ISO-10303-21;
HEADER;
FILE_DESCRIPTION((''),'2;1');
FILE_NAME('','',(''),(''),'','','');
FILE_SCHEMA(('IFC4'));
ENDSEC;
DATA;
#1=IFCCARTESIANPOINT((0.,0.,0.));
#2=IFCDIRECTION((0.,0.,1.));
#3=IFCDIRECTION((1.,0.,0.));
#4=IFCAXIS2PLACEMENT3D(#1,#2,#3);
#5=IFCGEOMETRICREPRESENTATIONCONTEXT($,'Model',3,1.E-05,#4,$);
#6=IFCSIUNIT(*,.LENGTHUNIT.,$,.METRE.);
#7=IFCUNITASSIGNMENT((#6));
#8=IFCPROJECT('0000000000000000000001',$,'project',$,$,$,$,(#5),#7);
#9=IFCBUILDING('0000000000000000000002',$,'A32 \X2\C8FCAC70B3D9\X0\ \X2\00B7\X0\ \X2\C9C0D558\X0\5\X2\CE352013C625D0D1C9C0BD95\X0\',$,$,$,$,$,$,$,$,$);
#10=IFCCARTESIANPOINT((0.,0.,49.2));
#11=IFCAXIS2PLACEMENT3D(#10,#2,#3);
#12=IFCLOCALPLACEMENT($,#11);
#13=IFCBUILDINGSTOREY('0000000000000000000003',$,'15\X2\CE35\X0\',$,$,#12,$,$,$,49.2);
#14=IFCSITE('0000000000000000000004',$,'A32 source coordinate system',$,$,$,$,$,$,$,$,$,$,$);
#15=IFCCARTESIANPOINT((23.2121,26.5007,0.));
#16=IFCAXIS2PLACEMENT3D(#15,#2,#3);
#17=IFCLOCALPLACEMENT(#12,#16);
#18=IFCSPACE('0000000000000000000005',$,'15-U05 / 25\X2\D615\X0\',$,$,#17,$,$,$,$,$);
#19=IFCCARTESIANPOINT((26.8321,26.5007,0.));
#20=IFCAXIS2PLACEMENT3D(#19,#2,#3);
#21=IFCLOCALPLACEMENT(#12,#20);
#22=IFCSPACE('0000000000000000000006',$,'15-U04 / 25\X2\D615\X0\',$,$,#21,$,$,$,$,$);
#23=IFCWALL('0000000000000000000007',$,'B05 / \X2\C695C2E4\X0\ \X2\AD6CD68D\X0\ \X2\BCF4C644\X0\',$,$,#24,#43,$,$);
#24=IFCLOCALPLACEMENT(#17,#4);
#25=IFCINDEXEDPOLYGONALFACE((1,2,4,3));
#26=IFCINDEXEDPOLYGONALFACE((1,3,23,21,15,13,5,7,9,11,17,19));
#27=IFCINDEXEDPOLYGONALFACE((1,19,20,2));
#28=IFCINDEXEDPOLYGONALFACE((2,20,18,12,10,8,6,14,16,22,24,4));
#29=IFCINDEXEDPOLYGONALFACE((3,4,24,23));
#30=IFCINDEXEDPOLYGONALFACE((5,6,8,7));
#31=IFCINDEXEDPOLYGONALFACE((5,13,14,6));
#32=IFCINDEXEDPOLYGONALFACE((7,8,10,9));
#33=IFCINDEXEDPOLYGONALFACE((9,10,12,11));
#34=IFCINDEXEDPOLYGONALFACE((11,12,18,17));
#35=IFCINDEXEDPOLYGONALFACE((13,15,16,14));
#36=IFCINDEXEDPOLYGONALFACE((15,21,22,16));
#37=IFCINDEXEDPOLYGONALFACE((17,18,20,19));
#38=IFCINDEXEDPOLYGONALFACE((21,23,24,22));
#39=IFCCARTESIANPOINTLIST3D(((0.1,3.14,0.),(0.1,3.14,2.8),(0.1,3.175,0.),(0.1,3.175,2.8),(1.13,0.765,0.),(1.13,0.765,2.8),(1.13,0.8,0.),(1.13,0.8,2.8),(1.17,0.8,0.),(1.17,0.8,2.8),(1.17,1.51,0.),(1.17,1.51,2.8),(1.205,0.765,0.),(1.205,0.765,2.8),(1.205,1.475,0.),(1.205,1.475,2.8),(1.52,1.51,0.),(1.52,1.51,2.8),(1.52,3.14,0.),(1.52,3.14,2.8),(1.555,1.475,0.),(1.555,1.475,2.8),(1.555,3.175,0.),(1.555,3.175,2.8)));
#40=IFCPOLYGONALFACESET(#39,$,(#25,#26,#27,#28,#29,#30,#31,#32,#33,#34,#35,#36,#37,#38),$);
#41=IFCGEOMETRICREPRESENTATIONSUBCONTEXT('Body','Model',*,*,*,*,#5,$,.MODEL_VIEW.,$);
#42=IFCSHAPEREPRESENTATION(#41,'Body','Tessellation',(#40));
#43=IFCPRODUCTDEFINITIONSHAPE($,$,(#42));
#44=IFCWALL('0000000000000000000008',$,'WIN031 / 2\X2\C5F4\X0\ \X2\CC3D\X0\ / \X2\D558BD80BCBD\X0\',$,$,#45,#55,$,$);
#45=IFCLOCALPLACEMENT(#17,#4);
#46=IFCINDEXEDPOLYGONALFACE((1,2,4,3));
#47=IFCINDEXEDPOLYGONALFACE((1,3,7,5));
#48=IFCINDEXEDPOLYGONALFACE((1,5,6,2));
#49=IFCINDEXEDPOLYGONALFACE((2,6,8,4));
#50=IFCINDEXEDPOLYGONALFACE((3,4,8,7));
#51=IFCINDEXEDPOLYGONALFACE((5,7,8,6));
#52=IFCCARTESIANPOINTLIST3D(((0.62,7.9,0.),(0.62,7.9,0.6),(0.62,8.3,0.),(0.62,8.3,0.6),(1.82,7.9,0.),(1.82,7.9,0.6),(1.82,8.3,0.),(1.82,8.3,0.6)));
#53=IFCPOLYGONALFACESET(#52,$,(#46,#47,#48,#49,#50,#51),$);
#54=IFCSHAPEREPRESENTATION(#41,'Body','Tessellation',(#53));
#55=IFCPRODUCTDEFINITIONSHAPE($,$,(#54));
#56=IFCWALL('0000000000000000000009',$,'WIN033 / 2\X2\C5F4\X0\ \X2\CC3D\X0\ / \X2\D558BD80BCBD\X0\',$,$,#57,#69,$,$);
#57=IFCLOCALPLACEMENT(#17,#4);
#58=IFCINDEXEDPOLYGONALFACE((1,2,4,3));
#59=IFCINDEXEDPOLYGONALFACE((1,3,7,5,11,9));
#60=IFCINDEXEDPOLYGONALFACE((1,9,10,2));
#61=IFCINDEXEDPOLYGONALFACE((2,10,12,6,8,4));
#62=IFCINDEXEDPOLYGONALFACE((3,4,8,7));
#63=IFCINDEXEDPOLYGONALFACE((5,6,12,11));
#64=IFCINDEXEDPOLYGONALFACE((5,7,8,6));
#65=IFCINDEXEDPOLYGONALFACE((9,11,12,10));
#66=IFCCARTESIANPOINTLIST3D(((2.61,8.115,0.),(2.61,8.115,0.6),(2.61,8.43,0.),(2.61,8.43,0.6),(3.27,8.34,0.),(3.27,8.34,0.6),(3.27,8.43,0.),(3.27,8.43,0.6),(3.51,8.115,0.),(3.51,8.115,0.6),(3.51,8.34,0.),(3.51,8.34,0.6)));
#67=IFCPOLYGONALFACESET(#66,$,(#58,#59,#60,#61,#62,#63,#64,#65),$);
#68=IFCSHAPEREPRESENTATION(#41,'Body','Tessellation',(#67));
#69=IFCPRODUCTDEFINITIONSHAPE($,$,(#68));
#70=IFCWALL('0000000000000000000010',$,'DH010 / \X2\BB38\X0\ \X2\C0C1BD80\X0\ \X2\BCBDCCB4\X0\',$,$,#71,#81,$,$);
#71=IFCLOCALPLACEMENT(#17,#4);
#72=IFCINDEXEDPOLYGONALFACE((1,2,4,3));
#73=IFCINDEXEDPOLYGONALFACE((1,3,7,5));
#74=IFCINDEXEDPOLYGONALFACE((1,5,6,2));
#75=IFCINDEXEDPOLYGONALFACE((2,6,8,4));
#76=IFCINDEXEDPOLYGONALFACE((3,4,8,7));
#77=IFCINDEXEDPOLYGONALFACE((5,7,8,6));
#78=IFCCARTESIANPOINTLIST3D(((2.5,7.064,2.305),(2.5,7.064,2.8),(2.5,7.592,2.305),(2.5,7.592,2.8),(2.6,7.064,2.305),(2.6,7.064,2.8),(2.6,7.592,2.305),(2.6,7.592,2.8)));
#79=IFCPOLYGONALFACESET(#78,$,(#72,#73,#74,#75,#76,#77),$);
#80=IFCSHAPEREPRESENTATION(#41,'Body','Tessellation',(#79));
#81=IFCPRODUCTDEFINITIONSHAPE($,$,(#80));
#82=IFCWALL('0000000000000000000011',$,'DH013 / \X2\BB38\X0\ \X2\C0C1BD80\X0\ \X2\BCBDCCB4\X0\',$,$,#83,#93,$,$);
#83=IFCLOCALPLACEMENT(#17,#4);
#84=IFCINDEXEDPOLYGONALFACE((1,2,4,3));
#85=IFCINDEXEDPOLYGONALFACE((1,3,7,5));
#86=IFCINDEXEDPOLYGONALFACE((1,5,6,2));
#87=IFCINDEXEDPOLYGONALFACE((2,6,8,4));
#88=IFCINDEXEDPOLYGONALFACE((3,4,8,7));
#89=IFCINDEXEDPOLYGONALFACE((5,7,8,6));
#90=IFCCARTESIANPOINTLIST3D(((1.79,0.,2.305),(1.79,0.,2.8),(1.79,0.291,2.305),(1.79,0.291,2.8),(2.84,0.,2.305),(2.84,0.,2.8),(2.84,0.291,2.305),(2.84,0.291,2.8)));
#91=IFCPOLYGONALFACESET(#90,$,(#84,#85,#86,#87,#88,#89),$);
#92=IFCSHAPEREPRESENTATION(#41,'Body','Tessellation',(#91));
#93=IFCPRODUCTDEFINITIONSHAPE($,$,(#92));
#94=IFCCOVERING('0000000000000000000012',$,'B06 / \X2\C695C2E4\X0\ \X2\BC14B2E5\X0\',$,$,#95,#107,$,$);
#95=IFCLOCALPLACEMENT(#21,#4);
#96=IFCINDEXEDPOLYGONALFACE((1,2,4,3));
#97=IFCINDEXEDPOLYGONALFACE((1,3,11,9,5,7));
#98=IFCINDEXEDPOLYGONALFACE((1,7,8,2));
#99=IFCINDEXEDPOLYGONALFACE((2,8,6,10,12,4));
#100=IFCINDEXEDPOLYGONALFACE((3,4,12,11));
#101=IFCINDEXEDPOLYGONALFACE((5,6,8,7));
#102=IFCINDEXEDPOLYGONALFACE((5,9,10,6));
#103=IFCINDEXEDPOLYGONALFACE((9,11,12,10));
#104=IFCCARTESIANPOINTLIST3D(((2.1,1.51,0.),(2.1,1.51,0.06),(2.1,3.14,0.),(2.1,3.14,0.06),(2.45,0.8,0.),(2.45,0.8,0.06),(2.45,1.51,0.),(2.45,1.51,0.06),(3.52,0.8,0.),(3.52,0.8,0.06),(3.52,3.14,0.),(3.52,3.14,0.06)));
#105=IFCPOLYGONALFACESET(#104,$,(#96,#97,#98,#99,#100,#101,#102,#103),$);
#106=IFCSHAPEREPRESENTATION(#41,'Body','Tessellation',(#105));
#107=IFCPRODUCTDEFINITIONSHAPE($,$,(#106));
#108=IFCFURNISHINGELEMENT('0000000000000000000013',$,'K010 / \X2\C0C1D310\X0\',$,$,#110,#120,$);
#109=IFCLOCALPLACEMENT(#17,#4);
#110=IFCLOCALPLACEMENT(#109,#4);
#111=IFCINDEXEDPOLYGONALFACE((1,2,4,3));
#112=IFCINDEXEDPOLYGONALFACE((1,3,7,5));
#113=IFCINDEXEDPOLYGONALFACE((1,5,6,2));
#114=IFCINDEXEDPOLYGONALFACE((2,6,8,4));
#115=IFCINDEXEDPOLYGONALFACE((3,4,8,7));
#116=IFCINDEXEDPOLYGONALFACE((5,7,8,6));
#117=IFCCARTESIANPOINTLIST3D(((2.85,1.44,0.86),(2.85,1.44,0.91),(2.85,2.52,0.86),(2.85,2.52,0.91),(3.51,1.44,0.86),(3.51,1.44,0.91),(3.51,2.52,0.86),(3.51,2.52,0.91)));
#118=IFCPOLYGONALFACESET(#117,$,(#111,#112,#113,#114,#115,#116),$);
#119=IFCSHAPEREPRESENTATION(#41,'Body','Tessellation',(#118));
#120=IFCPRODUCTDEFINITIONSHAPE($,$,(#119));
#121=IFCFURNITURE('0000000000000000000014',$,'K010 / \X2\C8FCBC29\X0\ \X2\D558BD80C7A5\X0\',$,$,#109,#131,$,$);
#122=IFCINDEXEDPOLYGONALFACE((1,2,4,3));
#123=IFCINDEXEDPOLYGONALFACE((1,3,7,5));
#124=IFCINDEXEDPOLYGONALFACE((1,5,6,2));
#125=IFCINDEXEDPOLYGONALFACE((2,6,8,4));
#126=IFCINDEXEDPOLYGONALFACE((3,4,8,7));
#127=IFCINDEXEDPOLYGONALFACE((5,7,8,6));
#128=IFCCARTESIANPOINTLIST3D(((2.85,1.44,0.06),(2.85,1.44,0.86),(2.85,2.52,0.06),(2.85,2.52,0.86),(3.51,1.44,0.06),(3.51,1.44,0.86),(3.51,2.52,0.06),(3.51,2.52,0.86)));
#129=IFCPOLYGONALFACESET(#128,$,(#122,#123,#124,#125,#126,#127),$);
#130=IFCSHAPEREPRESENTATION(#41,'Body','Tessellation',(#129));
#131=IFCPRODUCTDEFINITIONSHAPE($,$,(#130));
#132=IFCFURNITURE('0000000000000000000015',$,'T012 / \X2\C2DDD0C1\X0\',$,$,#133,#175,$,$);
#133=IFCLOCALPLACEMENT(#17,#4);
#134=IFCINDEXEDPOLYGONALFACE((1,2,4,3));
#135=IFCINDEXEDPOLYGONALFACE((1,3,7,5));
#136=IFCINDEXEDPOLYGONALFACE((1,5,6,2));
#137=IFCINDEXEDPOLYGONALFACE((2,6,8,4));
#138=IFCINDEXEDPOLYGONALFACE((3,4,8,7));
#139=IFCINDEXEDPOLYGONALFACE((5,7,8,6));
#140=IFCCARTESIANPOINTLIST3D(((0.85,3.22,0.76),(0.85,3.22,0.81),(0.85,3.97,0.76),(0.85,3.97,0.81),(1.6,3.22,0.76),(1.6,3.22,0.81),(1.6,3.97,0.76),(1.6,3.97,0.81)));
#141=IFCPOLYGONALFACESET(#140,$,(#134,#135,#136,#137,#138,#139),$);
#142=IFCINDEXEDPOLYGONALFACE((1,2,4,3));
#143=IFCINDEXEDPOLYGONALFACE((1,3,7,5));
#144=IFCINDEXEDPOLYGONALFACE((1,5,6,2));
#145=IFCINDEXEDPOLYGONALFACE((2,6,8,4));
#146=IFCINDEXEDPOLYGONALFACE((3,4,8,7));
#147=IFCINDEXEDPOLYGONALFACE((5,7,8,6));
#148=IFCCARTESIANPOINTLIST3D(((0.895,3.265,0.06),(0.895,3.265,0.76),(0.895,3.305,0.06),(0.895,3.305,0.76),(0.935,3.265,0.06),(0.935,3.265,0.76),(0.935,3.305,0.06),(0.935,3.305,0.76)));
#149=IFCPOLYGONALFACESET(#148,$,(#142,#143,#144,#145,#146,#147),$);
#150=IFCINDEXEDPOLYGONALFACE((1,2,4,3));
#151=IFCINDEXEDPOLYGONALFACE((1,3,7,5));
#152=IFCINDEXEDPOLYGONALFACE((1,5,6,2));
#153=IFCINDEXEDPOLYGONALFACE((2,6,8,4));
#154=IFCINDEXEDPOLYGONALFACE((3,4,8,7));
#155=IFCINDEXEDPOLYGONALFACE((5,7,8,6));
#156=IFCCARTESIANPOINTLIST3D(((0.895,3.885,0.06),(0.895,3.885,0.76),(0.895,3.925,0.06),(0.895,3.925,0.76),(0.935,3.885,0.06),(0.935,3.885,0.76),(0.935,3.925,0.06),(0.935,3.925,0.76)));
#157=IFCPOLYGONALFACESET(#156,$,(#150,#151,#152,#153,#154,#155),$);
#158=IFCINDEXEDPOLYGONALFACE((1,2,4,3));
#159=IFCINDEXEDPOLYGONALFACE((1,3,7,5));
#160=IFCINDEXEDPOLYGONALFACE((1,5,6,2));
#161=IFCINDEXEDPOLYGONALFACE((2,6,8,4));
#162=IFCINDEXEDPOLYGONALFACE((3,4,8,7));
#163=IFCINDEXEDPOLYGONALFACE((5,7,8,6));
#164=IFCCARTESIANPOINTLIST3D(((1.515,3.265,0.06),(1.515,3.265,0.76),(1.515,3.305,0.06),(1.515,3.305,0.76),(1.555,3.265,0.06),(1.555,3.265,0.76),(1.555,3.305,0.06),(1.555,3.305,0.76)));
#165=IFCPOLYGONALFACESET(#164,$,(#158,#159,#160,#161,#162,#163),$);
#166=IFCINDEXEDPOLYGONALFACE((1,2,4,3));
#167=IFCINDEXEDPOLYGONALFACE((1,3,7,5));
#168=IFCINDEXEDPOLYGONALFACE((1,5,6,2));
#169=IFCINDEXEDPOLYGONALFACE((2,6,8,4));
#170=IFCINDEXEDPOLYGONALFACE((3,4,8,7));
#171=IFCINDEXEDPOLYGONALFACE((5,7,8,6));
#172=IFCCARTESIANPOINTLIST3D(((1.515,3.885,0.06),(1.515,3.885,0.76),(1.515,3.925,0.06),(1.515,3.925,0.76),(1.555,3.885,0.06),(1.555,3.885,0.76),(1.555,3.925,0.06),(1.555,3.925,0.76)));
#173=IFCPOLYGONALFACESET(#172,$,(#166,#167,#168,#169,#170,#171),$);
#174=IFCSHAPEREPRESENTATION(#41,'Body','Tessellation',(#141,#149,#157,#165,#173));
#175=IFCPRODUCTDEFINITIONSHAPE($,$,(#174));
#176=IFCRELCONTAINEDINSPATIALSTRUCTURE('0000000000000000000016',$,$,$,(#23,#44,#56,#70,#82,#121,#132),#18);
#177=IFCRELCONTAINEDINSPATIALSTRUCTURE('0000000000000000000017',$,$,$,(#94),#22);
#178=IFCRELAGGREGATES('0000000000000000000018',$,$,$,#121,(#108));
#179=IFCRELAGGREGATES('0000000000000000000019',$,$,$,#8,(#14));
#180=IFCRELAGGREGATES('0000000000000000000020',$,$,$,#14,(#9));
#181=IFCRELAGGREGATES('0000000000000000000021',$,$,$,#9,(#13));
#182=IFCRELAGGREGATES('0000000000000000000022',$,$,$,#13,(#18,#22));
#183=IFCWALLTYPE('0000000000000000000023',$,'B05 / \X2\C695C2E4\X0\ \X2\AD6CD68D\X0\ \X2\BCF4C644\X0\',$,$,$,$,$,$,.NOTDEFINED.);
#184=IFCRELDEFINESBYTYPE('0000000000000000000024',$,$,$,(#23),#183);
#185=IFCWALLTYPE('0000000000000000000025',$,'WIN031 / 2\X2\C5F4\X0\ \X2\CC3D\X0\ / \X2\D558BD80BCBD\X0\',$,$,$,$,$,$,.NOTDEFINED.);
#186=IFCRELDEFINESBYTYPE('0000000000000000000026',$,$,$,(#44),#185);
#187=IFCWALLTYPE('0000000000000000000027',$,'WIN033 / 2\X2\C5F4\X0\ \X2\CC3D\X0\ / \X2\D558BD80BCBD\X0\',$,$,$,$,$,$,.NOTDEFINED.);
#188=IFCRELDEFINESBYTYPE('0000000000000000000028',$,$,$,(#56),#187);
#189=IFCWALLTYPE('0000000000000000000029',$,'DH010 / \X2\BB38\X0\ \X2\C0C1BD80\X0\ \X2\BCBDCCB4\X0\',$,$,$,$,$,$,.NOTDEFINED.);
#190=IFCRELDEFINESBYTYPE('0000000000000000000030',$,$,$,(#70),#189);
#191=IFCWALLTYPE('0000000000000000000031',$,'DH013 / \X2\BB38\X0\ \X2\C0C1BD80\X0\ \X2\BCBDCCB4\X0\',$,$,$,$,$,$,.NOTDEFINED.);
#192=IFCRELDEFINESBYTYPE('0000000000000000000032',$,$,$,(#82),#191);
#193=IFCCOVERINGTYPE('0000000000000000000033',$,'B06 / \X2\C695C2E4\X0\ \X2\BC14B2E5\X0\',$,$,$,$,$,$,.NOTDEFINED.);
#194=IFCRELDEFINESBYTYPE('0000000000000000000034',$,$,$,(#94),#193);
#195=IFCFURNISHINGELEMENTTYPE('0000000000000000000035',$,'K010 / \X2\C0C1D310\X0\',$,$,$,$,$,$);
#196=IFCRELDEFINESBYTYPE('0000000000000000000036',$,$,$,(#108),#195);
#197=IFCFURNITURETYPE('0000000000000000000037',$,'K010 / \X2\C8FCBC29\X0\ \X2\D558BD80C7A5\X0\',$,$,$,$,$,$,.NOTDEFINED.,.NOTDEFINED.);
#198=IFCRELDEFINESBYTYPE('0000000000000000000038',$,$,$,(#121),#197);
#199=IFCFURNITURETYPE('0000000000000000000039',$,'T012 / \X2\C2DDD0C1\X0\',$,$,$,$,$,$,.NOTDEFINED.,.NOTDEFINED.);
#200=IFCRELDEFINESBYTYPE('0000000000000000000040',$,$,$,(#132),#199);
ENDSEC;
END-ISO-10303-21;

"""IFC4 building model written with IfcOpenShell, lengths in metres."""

from ifc_helpers import new_model, si_unit, frame, origin, origin_with_axes, place, context, subcontext, project, spatial, polyline, outline, extrude, source, transform, mapped, type_object, type_shapes, element, aggregate, save


model = new_model("IFC4")

# Units and contexts
model_context = context("Model", 3, precision=1e-05, world=origin_with_axes())
body_context = subcontext(model_context, "Body", "Model", "MODEL_VIEW")
ifc_project = project(units=[si_unit("LENGTHUNIT", "METRE")], contexts=[model_context])

# Site, building, storey, space
site = spatial("IfcSite", under=ifc_project, Name="A32 source coordinate system")
building = spatial("IfcBuilding", under=site, Name="A32 주거동 · 지하5층–옥탑지붕")
storey_placement = place(None, frame((0.0, 0.0, 49.2), z_axis=(0.0, 0.0, 1.0), x_axis=(1.0, 0.0, 0.0)))
storey = spatial("IfcBuildingStorey", under=building, at=storey_placement, Name="15층", Elevation=49.2)
space_1_placement = place(storey_placement, frame((23.2121, 26.5007, 0.0), z_axis=(0.0, 0.0, 1.0), x_axis=(1.0, 0.0, 0.0)))
space_1 = spatial("IfcSpace", under=storey, at=space_1_placement, Name="15-U05 / 25형")

# Walls
wall_type_1 = type_object("IfcWallType", Name="B05 / 욕실 구획 보완", PredefinedType="NOTDEFINED")
shared_shape_1 = source(origin(), body_context, "Body", "SweptSolid", [
    extrude(outline(polyline([(1.17, 1.51), (1.52, 1.51), (1.52, 3.14), (0.1, 3.14), (0.1, 3.175), (1.555, 3.175), (1.555, 1.475), (1.205, 1.475), (1.205, 0.765), (1.13, 0.765), (1.13, 0.8), (1.17, 0.8), (1.17, 1.51)])), origin(), (0.0, 0.0, 1.0), 2.8),
])
type_shapes(wall_type_1, [shared_shape_1])
wall_1_placement = place(space_1_placement, origin_with_axes())
element("IfcWall", 1, at=wall_1_placement, inside=space_1, type_object=wall_type_1, Name="B05 / 욕실 구획 보완", context=body_context, shape_type="MappedRepresentation", body=[
    mapped(shared_shape_1, transform((0.0, 0.0, 0.0), scale=1.0)),
])
wall_type_2 = type_object("IfcWallType", Name="WIN031 / 2열 창 / 하부벽", PredefinedType="NOTDEFINED")
shared_shape_2 = source(origin(), body_context, "Body", "SweptSolid", [
    extrude(outline(polyline([(0.62, 8.3), (1.82, 8.3), (1.82, 7.9), (0.62, 7.9), (0.62, 8.3)])), origin(), (0.0, 0.0, 1.0), 0.6),
])
type_shapes(wall_type_2, [shared_shape_2])
wall_2_placement = place(space_1_placement, origin_with_axes())
element("IfcWall", 2, at=wall_2_placement, inside=space_1, type_object=wall_type_2, Name="WIN031 / 2열 창 / 하부벽", context=body_context, shape_type="MappedRepresentation", body=[
    mapped(shared_shape_2, transform((0.0, 0.0, 0.0), scale=1.0)),
])
wall_type_3 = type_object("IfcWallType", Name="WIN033 / 2열 창 / 하부벽", PredefinedType="NOTDEFINED")
shared_shape_3 = source(origin(), body_context, "Body", "SweptSolid", [
    extrude(outline(polyline([(2.61, 8.43), (3.27, 8.43), (3.27, 8.34), (3.51, 8.34), (3.51, 8.115), (2.61, 8.115), (2.61, 8.43)])), origin(), (0.0, 0.0, 1.0), 0.6),
])
type_shapes(wall_type_3, [shared_shape_3])
wall_3_placement = place(space_1_placement, origin_with_axes())
element("IfcWall", 3, at=wall_3_placement, inside=space_1, type_object=wall_type_3, Name="WIN033 / 2열 창 / 하부벽", context=body_context, shape_type="MappedRepresentation", body=[
    mapped(shared_shape_3, transform((0.0, 0.0, 0.0), scale=1.0)),
])
wall_type_4 = type_object("IfcWallType", Name="DH010 / 문 상부 벽체", PredefinedType="NOTDEFINED")
shared_shape_4 = source(origin(), body_context, "Body", "SweptSolid", [
    extrude(outline(polyline([(2.5, 7.592), (2.6, 7.592), (2.6, 7.064), (2.5, 7.064), (2.5, 7.592)])), frame((0.0, 0.0, 2.305)), (0.0, 0.0, 1.0), 0.495),
])
type_shapes(wall_type_4, [shared_shape_4])
wall_4_placement = place(space_1_placement, origin_with_axes())
element("IfcWall", 4, at=wall_4_placement, inside=space_1, type_object=wall_type_4, Name="DH010 / 문 상부 벽체", context=body_context, shape_type="MappedRepresentation", body=[
    mapped(shared_shape_4, transform((0.0, 0.0, 0.0), scale=1.0)),
])
wall_type_5 = type_object("IfcWallType", Name="DH013 / 문 상부 벽체", PredefinedType="NOTDEFINED")
shared_shape_5 = source(origin(), body_context, "Body", "SweptSolid", [
    extrude(outline(polyline([(2.84, 0.291), (2.84, 0.0), (1.79, 0.0), (1.79, 0.291), (2.84, 0.291)])), frame((0.0, 0.0, 2.305)), (0.0, 0.0, 1.0), 0.495),
])
type_shapes(wall_type_5, [shared_shape_5])
wall_5_placement = place(space_1_placement, origin_with_axes())
element("IfcWall", 5, at=wall_5_placement, inside=space_1, type_object=wall_type_5, Name="DH013 / 문 상부 벽체", context=body_context, shape_type="MappedRepresentation", body=[
    mapped(shared_shape_5, transform((0.0, 0.0, 0.0), scale=1.0)),
])

# Shared definitions
space_2_placement = place(storey_placement, frame((26.8321, 26.5007, 0.0), z_axis=(0.0, 0.0, 1.0), x_axis=(1.0, 0.0, 0.0)))
space_2 = spatial("IfcSpace", under=storey, at=space_2_placement, Name="15-U04 / 25형")

# Covering
covering_type = type_object("IfcCoveringType", Name="B06 / 욕실 바닥", PredefinedType="NOTDEFINED")
shared_shape_6 = source(origin(), body_context, "Body", "SweptSolid", [
    extrude(outline(polyline([(2.1, 3.14), (3.52, 3.14), (3.52, 0.8), (2.45, 0.8), (2.45, 1.51), (2.1, 1.51), (2.1, 3.14)])), origin(), (0.0, 0.0, 1.0), 0.06),
])
type_shapes(covering_type, [shared_shape_6])
covering_placement = place(space_2_placement, origin_with_axes())
element("IfcCovering", 6, at=covering_placement, inside=space_2, type_object=covering_type, Name="B06 / 욕실 바닥", context=body_context, shape_type="MappedRepresentation", body=[
    mapped(shared_shape_6, transform((0.0, 0.0, 0.0), scale=1.0)),
])

# Furnishing element
furnishing_element_type_1 = type_object("IfcFurnishingElementType", Name="K010 / 상판")
shared_shape_7 = source(origin(), body_context, "Body", "SweptSolid", [
    extrude(outline(polyline([(2.85, 2.52), (3.51, 2.52), (3.51, 1.44), (2.85, 1.44), (2.85, 2.52)])), frame((0.0, 0.0, 0.86)), (0.0, 0.0, 1.0), 0.05),
])
type_shapes(furnishing_element_type_1, [shared_shape_7])
furniture_1_placement = place(space_1_placement, origin_with_axes())
furnishing_1_placement = place(furniture_1_placement, origin_with_axes())
furnishing_1 = element("IfcFurnishingElement", 7, at=furnishing_1_placement, type_object=furnishing_element_type_1, Name="K010 / 상판", context=body_context, shape_type="MappedRepresentation", body=[
    mapped(shared_shape_7, transform((0.0, 0.0, 0.0), scale=1.0)),
])

# Furniture
furniture_type_1 = type_object("IfcFurnitureType", Name="K010 / 주방 하부장", AssemblyPlace="NOTDEFINED", PredefinedType="NOTDEFINED")
shared_shape_8 = source(origin(), body_context, "Body", "SweptSolid", [
    extrude(outline(polyline([(2.85, 1.44), (2.85, 2.52), (3.51, 2.52), (3.51, 1.44), (2.85, 1.44)])), frame((0.0, 0.0, 0.06)), (0.0, 0.0, 1.0), 0.8),
])
type_shapes(furniture_type_1, [shared_shape_8])
furniture_1 = element("IfcFurniture", 8, at=furniture_1_placement, inside=space_1, type_object=furniture_type_1, Name="K010 / 주방 하부장", context=body_context, shape_type="MappedRepresentation", body=[
    mapped(shared_shape_8, transform((0.0, 0.0, 0.0), scale=1.0)),
])
aggregate(furniture_1, [furnishing_1])
furniture_type_2 = type_object("IfcFurnitureType", Name="T012 / 식탁", AssemblyPlace="NOTDEFINED", PredefinedType="NOTDEFINED")
shared_shape_9 = source(origin(), body_context, "Body", "SweptSolid", [
    extrude(outline(polyline([(1.6, 3.97), (1.6, 3.22), (0.85, 3.22), (0.85, 3.97), (1.6, 3.97)])), frame((0.0, 0.0, 0.76)), (0.0, 0.0, 1.0), 0.05),
    extrude(outline(polyline([(0.895, 3.265), (0.895, 3.305), (0.935, 3.305), (0.935, 3.265), (0.895, 3.265)])), frame((0.0, 0.0, 0.06)), (0.0, 0.0, 1.0), 0.7),
    extrude(outline(polyline([(0.895, 3.885), (0.895, 3.925), (0.935, 3.925), (0.935, 3.885), (0.895, 3.885)])), frame((0.0, 0.0, 0.06)), (0.0, 0.0, 1.0), 0.7),
    extrude(outline(polyline([(1.515, 3.265), (1.515, 3.305), (1.555, 3.305), (1.555, 3.265), (1.515, 3.265)])), frame((0.0, 0.0, 0.06)), (0.0, 0.0, 1.0), 0.7),
    extrude(outline(polyline([(1.515, 3.885), (1.515, 3.925), (1.555, 3.925), (1.555, 3.885), (1.515, 3.885)])), frame((0.0, 0.0, 0.06)), (0.0, 0.0, 1.0), 0.7),
])
type_shapes(furniture_type_2, [shared_shape_9])
furniture_2_placement = place(space_1_placement, origin_with_axes())
element("IfcFurniture", 9, at=furniture_2_placement, inside=space_1, type_object=furniture_type_2, Name="T012 / 식탁", context=body_context, shape_type="MappedRepresentation", body=[
    mapped(shared_shape_9, transform((0.0, 0.0, 0.0), scale=1.0)),
])

save(model, "model.ifc")
